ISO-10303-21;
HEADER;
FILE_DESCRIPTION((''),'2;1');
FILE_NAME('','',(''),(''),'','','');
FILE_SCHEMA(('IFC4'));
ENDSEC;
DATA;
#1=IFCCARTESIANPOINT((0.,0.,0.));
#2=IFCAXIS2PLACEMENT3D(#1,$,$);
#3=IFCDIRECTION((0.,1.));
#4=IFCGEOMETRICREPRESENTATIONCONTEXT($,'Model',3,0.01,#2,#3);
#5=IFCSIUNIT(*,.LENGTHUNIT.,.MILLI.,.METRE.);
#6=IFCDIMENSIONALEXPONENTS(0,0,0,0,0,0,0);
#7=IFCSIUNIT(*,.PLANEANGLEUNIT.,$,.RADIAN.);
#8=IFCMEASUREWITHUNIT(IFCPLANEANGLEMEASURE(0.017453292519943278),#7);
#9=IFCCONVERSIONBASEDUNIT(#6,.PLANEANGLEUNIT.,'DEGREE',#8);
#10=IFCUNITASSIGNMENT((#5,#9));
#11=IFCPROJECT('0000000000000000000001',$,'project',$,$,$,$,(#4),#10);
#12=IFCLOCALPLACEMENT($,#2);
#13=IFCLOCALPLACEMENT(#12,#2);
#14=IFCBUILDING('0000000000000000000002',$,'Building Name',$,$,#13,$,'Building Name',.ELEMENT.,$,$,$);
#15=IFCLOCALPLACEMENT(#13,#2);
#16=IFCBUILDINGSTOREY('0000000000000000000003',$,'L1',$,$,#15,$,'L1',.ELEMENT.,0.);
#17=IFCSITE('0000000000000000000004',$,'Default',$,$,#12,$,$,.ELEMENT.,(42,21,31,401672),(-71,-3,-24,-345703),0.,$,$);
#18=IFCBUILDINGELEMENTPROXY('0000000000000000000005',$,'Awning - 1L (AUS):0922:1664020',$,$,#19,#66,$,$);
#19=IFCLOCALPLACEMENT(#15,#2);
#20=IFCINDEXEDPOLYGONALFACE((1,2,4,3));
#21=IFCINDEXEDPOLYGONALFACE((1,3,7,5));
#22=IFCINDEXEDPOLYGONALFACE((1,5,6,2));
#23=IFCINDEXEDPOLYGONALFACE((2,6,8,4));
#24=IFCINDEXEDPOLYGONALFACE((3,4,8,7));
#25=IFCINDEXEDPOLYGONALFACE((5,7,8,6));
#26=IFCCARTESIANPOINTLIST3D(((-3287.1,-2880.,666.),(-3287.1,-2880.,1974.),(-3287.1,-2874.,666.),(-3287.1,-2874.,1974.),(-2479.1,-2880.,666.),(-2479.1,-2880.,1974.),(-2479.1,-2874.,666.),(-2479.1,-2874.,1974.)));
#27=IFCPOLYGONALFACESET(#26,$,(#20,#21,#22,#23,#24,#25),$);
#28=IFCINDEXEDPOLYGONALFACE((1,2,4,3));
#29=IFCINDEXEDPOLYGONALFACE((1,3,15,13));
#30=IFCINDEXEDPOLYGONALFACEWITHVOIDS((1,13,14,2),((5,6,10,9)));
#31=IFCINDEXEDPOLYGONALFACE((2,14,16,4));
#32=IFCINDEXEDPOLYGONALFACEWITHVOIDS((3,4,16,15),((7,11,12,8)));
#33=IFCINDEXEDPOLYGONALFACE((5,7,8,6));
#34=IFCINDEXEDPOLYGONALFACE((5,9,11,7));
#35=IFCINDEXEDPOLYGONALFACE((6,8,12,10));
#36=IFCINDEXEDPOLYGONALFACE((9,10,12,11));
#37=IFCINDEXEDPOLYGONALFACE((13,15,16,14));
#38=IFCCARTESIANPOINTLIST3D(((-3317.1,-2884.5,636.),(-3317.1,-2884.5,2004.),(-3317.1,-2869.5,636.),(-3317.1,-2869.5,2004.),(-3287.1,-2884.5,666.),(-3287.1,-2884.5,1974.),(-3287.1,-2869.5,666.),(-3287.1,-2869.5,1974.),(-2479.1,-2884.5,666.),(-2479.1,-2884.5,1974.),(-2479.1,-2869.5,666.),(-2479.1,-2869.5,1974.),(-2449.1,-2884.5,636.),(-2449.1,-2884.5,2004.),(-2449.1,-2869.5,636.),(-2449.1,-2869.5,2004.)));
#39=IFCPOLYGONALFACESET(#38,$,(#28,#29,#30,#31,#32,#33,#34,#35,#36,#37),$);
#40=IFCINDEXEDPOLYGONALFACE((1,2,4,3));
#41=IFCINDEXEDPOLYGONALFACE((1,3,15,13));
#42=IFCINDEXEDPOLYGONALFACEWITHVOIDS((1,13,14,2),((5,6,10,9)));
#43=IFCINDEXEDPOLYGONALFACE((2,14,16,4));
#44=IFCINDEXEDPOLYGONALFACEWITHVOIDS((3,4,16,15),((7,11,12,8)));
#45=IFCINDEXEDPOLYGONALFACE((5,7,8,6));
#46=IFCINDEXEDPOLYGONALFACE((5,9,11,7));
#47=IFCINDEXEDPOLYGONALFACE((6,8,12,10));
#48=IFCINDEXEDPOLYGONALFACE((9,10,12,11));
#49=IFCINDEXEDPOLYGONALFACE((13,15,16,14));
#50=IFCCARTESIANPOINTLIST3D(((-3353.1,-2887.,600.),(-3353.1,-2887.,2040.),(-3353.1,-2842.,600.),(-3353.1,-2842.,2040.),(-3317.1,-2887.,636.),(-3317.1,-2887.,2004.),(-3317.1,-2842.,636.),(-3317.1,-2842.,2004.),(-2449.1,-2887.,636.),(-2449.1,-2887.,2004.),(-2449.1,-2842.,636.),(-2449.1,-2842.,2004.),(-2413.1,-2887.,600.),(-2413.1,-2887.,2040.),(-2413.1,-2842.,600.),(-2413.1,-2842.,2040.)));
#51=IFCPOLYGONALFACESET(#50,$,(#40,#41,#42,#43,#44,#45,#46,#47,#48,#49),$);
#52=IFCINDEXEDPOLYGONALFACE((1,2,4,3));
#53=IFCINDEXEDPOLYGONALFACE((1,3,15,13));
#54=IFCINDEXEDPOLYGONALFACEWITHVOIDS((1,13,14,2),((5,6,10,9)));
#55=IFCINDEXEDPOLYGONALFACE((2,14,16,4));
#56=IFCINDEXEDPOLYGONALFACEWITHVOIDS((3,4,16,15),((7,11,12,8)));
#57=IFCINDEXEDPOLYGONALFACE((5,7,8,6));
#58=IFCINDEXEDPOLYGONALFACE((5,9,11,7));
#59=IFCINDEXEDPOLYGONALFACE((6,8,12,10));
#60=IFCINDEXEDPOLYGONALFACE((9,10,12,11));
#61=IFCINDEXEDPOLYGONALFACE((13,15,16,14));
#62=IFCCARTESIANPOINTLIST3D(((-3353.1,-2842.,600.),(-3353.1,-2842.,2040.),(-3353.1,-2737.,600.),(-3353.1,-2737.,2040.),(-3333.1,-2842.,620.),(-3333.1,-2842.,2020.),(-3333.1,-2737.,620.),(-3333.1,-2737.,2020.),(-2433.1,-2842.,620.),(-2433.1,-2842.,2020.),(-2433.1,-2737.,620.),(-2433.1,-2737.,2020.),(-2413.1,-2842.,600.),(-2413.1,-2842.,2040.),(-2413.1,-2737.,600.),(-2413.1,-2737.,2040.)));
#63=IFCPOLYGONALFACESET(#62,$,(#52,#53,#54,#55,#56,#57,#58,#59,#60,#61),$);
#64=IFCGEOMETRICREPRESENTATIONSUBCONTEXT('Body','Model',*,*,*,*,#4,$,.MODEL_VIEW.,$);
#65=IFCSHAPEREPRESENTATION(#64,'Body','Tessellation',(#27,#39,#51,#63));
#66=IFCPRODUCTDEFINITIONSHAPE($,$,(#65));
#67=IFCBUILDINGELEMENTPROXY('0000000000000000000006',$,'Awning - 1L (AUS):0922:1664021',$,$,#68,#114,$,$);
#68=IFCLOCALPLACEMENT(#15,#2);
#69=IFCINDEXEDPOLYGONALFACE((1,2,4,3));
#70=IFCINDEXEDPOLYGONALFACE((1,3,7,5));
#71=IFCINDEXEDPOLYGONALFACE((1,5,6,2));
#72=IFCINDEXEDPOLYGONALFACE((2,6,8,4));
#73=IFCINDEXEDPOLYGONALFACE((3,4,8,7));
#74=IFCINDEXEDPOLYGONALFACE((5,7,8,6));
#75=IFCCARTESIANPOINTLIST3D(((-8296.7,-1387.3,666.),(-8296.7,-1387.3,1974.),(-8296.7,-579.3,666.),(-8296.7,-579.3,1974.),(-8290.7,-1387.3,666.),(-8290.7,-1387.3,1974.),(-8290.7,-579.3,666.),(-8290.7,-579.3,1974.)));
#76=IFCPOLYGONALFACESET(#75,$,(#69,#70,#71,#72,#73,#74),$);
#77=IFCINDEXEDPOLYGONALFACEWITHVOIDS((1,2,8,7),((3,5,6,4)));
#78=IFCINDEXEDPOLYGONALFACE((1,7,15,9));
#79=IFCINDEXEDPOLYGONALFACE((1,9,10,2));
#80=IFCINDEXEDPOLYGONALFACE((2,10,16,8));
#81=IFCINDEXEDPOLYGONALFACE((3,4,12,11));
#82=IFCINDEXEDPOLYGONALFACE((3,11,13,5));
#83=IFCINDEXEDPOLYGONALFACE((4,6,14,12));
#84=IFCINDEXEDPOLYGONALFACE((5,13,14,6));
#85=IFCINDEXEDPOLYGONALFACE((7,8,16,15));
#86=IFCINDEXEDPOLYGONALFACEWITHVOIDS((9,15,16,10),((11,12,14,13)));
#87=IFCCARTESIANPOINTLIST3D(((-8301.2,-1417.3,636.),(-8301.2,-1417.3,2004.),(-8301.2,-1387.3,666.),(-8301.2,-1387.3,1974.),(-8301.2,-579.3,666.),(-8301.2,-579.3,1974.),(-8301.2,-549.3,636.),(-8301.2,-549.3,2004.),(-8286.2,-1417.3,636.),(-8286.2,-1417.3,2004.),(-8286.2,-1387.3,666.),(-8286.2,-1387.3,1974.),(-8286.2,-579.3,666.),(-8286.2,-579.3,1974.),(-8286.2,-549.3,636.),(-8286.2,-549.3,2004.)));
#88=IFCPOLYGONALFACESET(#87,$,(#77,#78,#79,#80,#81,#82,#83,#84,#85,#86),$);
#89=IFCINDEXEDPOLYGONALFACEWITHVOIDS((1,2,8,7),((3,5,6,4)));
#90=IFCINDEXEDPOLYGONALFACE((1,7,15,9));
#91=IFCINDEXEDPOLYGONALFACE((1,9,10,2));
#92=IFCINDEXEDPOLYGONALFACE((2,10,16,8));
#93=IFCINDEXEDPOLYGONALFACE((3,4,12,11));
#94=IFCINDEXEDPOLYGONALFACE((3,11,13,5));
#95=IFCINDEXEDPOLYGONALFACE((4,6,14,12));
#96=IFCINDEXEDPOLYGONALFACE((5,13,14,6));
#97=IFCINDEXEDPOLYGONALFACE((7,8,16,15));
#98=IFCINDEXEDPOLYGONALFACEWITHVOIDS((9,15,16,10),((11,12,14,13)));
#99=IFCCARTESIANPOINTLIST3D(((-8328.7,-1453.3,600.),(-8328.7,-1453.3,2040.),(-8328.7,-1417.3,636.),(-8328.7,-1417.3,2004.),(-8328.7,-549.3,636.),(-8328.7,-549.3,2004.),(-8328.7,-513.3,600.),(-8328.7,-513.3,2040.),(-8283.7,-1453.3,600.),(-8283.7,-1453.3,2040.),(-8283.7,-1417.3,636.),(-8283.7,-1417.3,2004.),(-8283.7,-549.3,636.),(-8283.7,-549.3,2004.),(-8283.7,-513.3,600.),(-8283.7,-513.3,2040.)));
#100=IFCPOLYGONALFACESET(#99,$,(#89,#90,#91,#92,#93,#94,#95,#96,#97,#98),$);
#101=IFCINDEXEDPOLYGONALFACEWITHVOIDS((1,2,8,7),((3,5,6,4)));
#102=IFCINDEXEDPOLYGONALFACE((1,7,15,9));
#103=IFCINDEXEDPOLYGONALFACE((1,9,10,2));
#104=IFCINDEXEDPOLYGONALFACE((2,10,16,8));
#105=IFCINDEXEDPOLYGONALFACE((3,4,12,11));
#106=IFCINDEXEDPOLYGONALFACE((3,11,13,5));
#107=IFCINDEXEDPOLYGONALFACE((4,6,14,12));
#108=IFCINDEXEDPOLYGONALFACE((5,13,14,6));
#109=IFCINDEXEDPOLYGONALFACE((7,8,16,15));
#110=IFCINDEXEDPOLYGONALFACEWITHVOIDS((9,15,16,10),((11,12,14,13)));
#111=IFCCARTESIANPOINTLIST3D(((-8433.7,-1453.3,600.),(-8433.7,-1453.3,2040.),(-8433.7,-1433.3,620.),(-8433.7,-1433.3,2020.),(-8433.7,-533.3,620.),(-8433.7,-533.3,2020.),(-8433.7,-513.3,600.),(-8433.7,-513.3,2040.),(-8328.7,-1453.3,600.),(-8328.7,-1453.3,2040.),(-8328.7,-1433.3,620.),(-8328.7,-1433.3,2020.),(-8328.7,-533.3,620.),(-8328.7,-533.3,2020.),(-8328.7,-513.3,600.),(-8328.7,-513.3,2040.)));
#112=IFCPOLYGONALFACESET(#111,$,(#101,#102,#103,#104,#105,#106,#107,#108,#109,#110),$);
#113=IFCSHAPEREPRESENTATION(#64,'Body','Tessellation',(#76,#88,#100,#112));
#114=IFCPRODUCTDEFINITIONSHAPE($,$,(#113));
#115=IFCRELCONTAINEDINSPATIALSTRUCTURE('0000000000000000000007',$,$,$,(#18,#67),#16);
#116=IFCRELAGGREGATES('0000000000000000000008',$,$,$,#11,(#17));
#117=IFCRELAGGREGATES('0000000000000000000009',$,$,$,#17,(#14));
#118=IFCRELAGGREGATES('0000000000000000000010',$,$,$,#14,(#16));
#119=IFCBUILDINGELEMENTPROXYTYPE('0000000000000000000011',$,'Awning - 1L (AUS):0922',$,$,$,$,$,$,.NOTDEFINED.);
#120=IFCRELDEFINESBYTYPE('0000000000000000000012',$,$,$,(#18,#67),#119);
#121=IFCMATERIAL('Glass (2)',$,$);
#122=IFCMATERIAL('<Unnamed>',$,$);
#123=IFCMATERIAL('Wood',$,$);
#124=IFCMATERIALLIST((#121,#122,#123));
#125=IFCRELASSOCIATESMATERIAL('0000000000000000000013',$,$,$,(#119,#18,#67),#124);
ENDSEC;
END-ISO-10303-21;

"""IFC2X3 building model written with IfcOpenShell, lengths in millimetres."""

from ifc_helpers import new_model, entity, si_unit, converted_unit, direction, frame, frame_2d, origin, place, context, subcontext, project, spatial, polyline, rectangle, outline, extrude, source, transform, mapped, material, material_list, type_object, type_shapes, element, save


model = new_model("IFC2X3")

# Units and contexts
model_context = context("Model", 3, precision=0.01, world=origin(), true_north=direction((0.0, 1.0)))
body_context = subcontext(model_context, "Body", "Model", "MODEL_VIEW")
ifc_project = project(units=[si_unit("LENGTHUNIT", "METRE", prefix="MILLI"), converted_unit("PLANEANGLEUNIT", "DEGREE", entity("IfcPlaneAngleMeasure", 0.017453292519943278), si_unit("PLANEANGLEUNIT", "RADIAN"), dimensions=[0, 0, 0, 0, 0, 0, 0])], contexts=[model_context])

# Site, building, storey
site_placement = place(None, origin())
site = spatial("IfcSite", under=ifc_project, at=site_placement, Name="Default", CompositionType="ELEMENT", RefLatitude=(42, 21, 31, 401672), RefLongitude=(-71, -3, -24, -345703), RefElevation=0.0)
building_placement = place(site_placement, origin())
building = spatial("IfcBuilding", under=site, at=building_placement, Name="Building Name", LongName="Building Name", CompositionType="ELEMENT")
storey_placement = place(building_placement, origin())
storey = spatial("IfcBuildingStorey", under=building, at=storey_placement, Name="L1", LongName="L1", CompositionType="ELEMENT", Elevation=0.0)

# Building element proxies
ifc_material_1 = material(Name="Glass (2)")
ifc_material_2 = material(Name="<Unnamed>")
ifc_material_3 = material(Name="Wood")
ifc_material_list_1 = material_list([ifc_material_1, ifc_material_2, ifc_material_3])
building_element_proxy_type_1 = type_object("IfcBuildingElementProxyType", Name="Awning - 1L (AUS):0922", PredefinedType="NOTDEFINED", material=ifc_material_list_1)
shared_shape_1 = source(origin(), body_context, "Body", "SweptSolid", [
    extrude(rectangle(XDim=6.0, YDim=808.0, at=frame_2d((0.0, 0.0), x_axis=(1.0, 0.0))), frame((326.2, 12.5, 966.0), z_axis=(0.0, 0.0, 1.0), x_axis=(0.0, 1.0, 0.0)), (0.0, 0.0, 1.0), 1308.0),
    extrude(outline(polyline([(-684.0, -434.0), (684.0, -434.0), (684.0, 434.0), (-684.0, 434.0), (-684.0, -434.0)]), holes=[polyline([(654.0, -404.0), (-654.0, -404.0), (-654.0, 404.0), (654.0, 404.0), (654.0, -404.0)])]), frame((326.2, 5.0, 1620.0), z_axis=(0.0, 1.0, 0.0), x_axis=(0.0, 0.0, 1.0)), (0.0, 0.0, 1.0), 15.0),
    extrude(outline(polyline([(-720.0, -470.0), (720.0, -470.0), (720.0, 470.0), (-720.0, 470.0), (-720.0, -470.0)]), holes=[polyline([(684.0, -434.0), (-684.0, -434.0), (-684.0, 434.0), (684.0, 434.0), (684.0, -434.0)])]), frame((326.2, -22.5, 1620.0), z_axis=(0.0, 1.0, 0.0), x_axis=(0.0, 0.0, 1.0)), (0.0, 0.0, 1.0), 45.0),
    extrude(outline(polyline([(-720.0, -470.0), (720.0, -470.0), (720.0, 470.0), (-720.0, 470.0), (-720.0, -470.0)]), holes=[polyline([(700.0, -450.0), (-700.0, -450.0), (-700.0, 450.0), (700.0, 450.0), (700.0, -450.0)])]), frame((326.2, -127.5, 1620.0), z_axis=(0.0, 1.0, 0.0), x_axis=(0.0, 0.0, 1.0)), (0.0, 0.0, 1.0), 105.0),
])
type_shapes(building_element_proxy_type_1, [shared_shape_1])
for number, where, z_axis, x_axis, name in (
    (1, (-2556.9, -2864.5, -300.0), (0.0, 0.0, 1.0), (-1.0, 0.0, 0.0), "Awning - 1L (AUS):0922:1664020"),
    (2, (-8306.2, -657.1, -300.0), (0.0, 0.0, 1.0), (0.0, -1.0, 0.0), "Awning - 1L (AUS):0922:1664021"),
):
    element("IfcBuildingElementProxy", number, at=place(storey_placement, frame(where, z_axis=z_axis, x_axis=x_axis)), inside=storey, type_object=building_element_proxy_type_1, material=ifc_material_list_1, Name=name, context=body_context, shape_type="MappedRepresentation", body=[
        mapped(shared_shape_1, transform((0.0, 0.0, 0.0), scale=1.0)),
    ])

save(model, "model.ifc")
